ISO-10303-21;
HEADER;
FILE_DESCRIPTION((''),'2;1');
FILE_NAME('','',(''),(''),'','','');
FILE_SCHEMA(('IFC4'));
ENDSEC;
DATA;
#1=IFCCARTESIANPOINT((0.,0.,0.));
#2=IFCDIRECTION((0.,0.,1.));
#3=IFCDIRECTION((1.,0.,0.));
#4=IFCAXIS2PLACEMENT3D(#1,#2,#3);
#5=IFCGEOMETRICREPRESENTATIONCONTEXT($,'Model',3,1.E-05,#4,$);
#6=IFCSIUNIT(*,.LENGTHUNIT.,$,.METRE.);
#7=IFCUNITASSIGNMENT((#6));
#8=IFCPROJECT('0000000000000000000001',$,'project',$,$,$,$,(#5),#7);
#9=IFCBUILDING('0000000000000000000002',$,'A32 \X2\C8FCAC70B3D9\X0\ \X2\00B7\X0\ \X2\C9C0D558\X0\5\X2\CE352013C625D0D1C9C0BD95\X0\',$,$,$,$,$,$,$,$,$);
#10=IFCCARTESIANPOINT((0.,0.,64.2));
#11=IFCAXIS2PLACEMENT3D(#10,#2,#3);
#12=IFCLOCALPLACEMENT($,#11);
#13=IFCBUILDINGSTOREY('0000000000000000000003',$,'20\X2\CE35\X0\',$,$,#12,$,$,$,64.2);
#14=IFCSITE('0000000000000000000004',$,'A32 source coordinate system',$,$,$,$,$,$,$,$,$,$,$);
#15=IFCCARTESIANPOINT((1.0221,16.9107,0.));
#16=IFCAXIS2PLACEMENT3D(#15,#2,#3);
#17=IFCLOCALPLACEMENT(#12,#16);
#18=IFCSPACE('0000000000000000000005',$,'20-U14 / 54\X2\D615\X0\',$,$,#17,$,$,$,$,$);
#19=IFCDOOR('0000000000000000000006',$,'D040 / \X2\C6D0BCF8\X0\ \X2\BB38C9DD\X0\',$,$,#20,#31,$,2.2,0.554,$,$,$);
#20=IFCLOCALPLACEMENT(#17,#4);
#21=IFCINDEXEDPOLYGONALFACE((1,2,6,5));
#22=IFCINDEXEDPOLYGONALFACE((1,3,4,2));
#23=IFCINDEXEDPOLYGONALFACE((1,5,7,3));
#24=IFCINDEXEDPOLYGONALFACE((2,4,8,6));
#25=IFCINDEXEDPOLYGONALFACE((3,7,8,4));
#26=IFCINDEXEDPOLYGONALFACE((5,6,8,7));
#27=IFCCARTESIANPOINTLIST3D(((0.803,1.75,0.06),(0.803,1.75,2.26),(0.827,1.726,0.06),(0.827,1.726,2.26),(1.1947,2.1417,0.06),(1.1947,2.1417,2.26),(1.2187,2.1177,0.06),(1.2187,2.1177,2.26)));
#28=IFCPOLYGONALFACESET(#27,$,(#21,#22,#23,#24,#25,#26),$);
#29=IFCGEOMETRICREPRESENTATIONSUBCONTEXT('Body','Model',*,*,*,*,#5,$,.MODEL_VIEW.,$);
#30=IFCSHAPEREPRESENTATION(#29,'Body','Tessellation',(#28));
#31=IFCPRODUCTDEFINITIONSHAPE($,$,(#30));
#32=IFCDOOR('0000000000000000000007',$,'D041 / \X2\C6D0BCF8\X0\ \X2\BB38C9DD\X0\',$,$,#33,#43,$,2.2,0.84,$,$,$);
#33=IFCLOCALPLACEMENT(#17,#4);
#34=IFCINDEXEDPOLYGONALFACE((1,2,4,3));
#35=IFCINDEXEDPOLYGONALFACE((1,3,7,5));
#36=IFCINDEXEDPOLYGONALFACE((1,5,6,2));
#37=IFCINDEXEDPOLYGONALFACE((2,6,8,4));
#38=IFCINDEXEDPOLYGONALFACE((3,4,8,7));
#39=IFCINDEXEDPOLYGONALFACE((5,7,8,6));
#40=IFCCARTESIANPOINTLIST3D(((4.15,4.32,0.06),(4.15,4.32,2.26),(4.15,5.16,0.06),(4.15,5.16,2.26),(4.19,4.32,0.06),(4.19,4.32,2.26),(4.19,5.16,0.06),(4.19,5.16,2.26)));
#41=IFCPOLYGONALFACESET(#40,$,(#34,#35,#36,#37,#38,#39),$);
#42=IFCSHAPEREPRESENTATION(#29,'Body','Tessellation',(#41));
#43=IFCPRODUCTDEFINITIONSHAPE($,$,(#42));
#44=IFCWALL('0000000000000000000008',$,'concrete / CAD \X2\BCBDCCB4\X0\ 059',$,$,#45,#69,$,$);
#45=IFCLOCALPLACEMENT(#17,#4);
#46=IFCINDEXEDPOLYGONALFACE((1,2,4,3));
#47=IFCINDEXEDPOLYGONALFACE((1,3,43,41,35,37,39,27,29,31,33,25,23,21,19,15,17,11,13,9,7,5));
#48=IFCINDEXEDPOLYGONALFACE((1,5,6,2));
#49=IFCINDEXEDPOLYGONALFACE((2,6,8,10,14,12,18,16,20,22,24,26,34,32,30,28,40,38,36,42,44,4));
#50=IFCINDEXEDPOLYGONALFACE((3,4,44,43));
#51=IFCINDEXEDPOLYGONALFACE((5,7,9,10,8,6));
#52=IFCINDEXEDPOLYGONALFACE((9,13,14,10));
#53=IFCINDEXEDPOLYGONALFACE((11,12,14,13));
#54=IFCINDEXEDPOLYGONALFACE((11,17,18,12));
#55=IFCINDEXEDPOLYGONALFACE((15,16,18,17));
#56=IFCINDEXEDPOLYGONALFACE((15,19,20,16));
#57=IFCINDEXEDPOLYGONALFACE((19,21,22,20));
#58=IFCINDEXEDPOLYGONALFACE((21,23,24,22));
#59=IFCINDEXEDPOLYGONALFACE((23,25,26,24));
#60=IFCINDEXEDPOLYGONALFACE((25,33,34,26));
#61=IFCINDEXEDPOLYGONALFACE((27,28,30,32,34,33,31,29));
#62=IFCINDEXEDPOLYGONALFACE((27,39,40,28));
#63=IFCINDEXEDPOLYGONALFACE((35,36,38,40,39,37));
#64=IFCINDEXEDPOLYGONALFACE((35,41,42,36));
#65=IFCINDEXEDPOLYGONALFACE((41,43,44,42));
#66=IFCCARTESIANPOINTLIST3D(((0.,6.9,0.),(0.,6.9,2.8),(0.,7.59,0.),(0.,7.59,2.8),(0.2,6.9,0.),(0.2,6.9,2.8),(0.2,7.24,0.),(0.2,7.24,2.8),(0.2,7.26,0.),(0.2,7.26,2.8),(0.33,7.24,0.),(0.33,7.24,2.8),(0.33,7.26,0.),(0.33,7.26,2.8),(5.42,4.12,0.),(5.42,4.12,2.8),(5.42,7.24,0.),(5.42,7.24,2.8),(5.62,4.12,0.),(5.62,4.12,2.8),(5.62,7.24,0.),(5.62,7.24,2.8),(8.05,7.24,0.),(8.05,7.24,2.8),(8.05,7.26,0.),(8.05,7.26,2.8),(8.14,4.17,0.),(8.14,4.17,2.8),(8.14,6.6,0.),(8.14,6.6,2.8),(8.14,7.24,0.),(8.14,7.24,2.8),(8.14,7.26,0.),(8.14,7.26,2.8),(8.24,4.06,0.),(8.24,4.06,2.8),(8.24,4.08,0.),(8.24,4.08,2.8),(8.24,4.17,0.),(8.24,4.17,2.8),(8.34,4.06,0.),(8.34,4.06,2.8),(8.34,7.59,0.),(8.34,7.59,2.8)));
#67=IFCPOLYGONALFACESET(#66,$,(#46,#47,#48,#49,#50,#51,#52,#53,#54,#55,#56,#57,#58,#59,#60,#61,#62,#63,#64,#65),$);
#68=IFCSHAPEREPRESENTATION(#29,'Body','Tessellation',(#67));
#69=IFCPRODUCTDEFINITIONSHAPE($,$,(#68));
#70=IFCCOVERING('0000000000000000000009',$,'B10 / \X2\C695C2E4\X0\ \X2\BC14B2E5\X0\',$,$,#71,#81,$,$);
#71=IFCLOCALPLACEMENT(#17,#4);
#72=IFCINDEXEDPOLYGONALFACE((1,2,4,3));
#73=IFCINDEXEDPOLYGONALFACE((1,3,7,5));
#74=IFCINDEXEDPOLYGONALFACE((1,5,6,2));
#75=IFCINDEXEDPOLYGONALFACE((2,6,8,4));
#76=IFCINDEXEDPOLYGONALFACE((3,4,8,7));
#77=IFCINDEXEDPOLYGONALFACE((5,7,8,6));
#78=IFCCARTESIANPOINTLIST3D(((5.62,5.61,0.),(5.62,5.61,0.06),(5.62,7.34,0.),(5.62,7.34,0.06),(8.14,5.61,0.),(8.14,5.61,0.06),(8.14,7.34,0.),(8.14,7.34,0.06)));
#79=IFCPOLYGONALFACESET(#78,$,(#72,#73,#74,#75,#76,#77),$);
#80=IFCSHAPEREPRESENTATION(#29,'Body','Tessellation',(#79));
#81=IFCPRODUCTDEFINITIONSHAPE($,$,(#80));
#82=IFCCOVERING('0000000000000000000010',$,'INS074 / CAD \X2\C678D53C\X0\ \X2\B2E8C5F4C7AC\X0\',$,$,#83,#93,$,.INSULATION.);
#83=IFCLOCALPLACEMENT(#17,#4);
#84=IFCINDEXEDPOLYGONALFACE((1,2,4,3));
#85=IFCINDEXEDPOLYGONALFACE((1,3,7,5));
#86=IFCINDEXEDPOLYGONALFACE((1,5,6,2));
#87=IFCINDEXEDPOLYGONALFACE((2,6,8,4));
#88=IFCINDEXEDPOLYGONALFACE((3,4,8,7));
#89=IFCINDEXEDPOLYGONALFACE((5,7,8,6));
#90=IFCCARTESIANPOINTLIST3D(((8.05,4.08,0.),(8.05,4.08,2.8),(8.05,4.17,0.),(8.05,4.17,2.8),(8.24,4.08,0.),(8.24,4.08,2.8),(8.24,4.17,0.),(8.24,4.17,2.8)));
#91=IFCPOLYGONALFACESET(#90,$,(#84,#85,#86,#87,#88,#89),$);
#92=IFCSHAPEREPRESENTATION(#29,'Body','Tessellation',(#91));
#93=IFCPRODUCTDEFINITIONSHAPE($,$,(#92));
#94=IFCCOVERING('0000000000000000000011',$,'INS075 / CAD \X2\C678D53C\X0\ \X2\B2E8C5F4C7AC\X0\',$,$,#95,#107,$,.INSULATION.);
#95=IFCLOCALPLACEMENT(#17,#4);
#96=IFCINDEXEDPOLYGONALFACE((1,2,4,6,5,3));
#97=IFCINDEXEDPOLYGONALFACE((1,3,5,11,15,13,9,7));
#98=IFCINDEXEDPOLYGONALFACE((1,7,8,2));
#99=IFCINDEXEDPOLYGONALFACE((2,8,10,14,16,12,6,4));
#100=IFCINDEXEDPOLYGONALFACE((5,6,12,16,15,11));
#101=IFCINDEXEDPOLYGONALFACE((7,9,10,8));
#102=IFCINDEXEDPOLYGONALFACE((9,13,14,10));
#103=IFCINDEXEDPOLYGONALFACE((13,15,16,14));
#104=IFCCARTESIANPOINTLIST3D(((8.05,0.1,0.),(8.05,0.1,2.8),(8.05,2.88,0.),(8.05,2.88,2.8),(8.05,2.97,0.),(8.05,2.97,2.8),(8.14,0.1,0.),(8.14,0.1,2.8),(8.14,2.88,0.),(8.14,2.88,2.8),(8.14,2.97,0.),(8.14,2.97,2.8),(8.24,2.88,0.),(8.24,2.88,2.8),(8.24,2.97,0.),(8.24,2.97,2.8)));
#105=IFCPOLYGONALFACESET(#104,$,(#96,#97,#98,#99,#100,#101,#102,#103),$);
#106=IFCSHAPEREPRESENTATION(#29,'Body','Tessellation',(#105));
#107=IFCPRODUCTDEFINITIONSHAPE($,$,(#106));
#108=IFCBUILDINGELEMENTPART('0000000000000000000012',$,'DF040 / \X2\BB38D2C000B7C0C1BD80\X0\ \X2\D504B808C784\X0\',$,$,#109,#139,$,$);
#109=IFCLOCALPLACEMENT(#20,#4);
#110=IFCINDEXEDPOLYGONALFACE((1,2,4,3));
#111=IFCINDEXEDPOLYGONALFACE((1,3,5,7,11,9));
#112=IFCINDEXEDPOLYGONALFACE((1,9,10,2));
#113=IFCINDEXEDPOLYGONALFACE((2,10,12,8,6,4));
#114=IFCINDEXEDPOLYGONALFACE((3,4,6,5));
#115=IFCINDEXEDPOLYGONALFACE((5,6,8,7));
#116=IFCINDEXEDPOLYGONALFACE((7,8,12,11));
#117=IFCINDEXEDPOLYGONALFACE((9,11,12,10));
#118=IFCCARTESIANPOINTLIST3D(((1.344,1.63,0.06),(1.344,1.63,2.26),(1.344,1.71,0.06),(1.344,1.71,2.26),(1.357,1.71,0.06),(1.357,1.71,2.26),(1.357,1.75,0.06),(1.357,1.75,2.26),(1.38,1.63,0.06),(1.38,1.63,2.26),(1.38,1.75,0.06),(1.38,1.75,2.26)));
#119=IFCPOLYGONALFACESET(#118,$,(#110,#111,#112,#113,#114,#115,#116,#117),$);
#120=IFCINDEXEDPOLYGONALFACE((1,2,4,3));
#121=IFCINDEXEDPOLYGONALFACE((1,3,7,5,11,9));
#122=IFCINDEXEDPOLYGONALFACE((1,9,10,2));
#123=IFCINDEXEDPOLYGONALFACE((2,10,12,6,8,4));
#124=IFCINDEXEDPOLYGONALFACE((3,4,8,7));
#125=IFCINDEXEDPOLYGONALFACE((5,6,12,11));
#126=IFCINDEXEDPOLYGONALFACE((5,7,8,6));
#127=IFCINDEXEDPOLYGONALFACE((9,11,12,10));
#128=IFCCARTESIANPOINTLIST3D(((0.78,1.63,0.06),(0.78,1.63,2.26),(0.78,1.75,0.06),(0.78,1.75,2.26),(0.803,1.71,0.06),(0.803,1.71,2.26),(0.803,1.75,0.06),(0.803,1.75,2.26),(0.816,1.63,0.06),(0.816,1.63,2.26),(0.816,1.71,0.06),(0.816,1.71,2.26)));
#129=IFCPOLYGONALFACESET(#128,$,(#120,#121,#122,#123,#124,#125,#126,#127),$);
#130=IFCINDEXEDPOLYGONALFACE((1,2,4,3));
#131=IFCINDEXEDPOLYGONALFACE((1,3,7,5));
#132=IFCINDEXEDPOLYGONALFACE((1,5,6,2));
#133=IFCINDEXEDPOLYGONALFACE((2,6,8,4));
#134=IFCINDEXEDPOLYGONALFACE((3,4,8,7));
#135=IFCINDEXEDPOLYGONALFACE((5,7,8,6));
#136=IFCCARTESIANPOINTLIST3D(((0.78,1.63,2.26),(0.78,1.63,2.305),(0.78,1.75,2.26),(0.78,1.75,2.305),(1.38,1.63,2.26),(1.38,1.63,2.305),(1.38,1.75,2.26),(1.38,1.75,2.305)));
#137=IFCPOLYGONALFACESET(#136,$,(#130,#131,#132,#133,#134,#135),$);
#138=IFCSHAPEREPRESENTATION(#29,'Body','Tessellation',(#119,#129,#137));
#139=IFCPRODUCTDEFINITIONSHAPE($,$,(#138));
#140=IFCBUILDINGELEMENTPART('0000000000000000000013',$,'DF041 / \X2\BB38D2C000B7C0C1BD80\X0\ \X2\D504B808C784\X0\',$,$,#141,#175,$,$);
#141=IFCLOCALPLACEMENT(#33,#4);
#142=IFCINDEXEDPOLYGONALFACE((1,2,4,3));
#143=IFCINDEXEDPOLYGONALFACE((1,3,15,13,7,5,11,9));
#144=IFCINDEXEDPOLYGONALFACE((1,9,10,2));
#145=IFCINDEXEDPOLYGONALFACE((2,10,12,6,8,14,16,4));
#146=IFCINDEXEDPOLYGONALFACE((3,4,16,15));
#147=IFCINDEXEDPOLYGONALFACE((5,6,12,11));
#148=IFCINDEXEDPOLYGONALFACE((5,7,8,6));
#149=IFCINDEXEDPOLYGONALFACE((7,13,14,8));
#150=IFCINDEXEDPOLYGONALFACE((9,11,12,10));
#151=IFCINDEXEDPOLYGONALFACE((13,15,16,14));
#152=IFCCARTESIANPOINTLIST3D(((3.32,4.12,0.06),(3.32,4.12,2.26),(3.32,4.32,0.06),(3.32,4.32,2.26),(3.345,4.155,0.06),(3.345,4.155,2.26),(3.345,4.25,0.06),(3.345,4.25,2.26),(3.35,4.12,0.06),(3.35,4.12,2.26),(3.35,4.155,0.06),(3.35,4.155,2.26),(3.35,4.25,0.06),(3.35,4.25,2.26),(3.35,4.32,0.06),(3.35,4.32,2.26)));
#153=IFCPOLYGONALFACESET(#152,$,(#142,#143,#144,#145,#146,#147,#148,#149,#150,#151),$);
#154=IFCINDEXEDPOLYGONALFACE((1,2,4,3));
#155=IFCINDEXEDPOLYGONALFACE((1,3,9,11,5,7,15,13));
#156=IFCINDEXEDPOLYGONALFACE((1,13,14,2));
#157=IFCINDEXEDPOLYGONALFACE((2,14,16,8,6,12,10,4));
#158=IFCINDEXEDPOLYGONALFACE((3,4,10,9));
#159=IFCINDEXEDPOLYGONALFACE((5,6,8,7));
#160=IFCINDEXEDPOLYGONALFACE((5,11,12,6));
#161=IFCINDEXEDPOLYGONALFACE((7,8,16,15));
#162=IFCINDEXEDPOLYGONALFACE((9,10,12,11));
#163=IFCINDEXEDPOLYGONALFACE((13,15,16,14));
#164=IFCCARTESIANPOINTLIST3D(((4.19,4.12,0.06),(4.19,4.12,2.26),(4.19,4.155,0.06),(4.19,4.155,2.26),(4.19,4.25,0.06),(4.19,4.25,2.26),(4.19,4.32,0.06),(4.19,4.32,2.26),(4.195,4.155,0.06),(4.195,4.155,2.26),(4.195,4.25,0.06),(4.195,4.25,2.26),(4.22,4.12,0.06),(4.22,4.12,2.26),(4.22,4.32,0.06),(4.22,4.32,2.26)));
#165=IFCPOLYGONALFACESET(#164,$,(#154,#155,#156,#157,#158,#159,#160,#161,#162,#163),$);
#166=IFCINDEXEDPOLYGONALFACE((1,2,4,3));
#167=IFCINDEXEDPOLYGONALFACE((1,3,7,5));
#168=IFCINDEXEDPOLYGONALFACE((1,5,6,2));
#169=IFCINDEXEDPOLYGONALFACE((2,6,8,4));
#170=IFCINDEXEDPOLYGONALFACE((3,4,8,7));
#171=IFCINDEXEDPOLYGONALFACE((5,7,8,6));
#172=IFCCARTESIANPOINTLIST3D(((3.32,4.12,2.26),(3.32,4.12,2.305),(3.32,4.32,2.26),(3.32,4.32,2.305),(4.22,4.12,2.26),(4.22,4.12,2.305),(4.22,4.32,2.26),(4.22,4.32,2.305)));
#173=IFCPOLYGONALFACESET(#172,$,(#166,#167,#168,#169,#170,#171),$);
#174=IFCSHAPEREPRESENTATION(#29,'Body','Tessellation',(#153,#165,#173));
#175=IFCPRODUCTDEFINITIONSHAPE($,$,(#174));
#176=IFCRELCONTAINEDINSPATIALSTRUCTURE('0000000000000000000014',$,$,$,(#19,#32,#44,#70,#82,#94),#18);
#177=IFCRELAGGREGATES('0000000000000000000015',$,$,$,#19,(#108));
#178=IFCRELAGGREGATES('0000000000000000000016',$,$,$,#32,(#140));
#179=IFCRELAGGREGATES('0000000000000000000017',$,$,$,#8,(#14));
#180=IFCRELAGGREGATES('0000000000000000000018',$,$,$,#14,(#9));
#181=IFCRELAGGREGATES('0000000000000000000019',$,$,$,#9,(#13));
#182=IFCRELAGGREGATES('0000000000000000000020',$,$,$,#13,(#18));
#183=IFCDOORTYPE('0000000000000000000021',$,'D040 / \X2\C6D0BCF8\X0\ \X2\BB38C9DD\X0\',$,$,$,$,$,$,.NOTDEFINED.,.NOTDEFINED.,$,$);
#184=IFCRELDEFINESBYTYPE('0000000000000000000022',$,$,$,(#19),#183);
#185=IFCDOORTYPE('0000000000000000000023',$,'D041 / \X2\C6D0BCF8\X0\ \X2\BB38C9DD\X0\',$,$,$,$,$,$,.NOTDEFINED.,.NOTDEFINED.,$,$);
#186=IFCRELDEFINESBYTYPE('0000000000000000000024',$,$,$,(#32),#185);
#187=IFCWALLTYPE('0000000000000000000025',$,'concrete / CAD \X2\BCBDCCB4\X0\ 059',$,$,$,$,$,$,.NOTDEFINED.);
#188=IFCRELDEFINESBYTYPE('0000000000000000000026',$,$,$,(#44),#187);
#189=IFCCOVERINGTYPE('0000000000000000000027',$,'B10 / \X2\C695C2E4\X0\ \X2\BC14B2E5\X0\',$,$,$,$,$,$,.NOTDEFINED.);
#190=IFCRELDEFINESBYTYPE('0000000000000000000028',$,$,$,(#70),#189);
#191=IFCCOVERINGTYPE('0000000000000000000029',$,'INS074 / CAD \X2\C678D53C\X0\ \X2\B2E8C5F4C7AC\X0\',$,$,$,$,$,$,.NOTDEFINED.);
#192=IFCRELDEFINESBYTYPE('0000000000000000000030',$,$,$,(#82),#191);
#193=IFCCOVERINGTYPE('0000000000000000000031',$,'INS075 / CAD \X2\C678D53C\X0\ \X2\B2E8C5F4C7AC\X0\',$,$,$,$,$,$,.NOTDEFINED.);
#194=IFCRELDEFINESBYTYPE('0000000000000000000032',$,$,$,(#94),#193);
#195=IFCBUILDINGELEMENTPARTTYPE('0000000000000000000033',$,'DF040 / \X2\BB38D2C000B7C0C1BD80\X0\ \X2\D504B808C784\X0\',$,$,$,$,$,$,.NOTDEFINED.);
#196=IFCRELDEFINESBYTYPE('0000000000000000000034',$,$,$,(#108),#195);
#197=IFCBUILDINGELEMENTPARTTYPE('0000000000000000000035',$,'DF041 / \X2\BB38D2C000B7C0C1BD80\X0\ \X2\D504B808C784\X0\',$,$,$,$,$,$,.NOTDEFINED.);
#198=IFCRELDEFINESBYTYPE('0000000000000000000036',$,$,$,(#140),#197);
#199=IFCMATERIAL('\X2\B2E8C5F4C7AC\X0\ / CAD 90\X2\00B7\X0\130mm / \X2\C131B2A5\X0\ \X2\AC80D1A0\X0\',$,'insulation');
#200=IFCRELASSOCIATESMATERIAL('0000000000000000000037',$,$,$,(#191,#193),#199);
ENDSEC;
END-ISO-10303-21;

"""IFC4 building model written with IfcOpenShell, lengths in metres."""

from ifc_helpers import new_model, si_unit, frame, origin, origin_with_axes, place, context, subcontext, project, spatial, polyline, outline, extrude, source, transform, mapped, material, type_object, type_shapes, element, aggregate, save


model = new_model("IFC4")

# Units and contexts
model_context = context("Model", 3, precision=1e-05, world=origin_with_axes())
body_context = subcontext(model_context, "Body", "Model", "MODEL_VIEW")
ifc_project = project(units=[si_unit("LENGTHUNIT", "METRE")], contexts=[model_context])

# Site, building, storey, space
storey_placement = place(None, frame((0.0, 0.0, 64.2), z_axis=(0.0, 0.0, 1.0), x_axis=(1.0, 0.0, 0.0)))
space_1_placement = place(storey_placement, frame((1.0221, 16.9107, 0.0), z_axis=(0.0, 0.0, 1.0), x_axis=(1.0, 0.0, 0.0)))
site = spatial("IfcSite", under=ifc_project, Name="A32 source coordinate system")
building = spatial("IfcBuilding", under=site, Name="A32 주거동 · 지하5층–옥탑지붕")
storey = spatial("IfcBuildingStorey", under=building, at=storey_placement, Name="20층", Elevation=64.2)
space_1 = spatial("IfcSpace", under=storey, at=space_1_placement, Name="20-U14 / 54형")

# Doors
door_type_1 = type_object("IfcDoorType", Name="D040 / 원본 문짝", OperationType="NOTDEFINED", PredefinedType="NOTDEFINED")
shared_shape_1 = source(origin(), body_context, "Body", "SweptSolid", [
    extrude(outline(polyline([(0.803, 1.75), (1.1947, 2.1417), (1.2187, 2.1177), (0.827, 1.726), (0.803, 1.75)])), frame((0.0, 0.0, 0.06)), (0.0, 0.0, 1.0), 2.2),
])
type_shapes(door_type_1, [shared_shape_1])
door_1_placement = place(space_1_placement, origin_with_axes())
door_1 = element("IfcDoor", 1, at=door_1_placement, inside=space_1, type_object=door_type_1, Name="D040 / 원본 문짝", OverallHeight=2.2, OverallWidth=0.554, context=body_context, shape_type="MappedRepresentation", body=[
    mapped(shared_shape_1, transform((0.0, 0.0, 0.0), scale=1.0)),
])
door_type_2 = type_object("IfcDoorType", Name="D041 / 원본 문짝", OperationType="NOTDEFINED", PredefinedType="NOTDEFINED")
shared_shape_2 = source(origin(), body_context, "Body", "SweptSolid", [
    extrude(outline(polyline([(4.15, 5.16), (4.19, 5.16), (4.19, 4.32), (4.15, 4.32), (4.15, 5.16)])), frame((0.0, 0.0, 0.06)), (0.0, 0.0, 1.0), 2.2),
])
type_shapes(door_type_2, [shared_shape_2])
door_2_placement = place(space_1_placement, origin_with_axes())
door_2 = element("IfcDoor", 2, at=door_2_placement, inside=space_1, type_object=door_type_2, Name="D041 / 원본 문짝", OverallHeight=2.2, OverallWidth=0.84, context=body_context, shape_type="MappedRepresentation", body=[
    mapped(shared_shape_2, transform((0.0, 0.0, 0.0), scale=1.0)),
])

# Wall
wall_type_1 = type_object("IfcWallType", Name="concrete / CAD 벽체 059", PredefinedType="NOTDEFINED")
shared_shape_3 = source(origin(), body_context, "Body", "SweptSolid", [
    extrude(outline(polyline([(8.05, 7.26), (8.05, 7.24), (5.62, 7.24), (5.62, 4.12), (5.42, 4.12), (5.42, 7.24), (0.33, 7.24), (0.33, 7.26), (0.2, 7.26), (0.2, 7.24), (0.2, 6.9), (0.0, 6.9), (0.0, 7.59), (8.34, 7.59), (8.34, 4.06), (8.24, 4.06), (8.24, 4.08), (8.24, 4.17), (8.14, 4.17), (8.14, 6.6), (8.14, 7.24), (8.14, 7.26), (8.05, 7.26)])), origin(), (0.0, 0.0, 1.0), 2.8),
])
type_shapes(wall_type_1, [shared_shape_3])
wall_1_placement = place(space_1_placement, origin_with_axes())
element("IfcWall", 3, at=wall_1_placement, inside=space_1, type_object=wall_type_1, Name="concrete / CAD 벽체 059", context=body_context, shape_type="MappedRepresentation", body=[
    mapped(shared_shape_3, transform((0.0, 0.0, 0.0), scale=1.0)),
])

# Coverings
covering_type_1 = type_object("IfcCoveringType", Name="B10 / 욕실 바닥", PredefinedType="NOTDEFINED")
shared_shape_4 = source(origin(), body_context, "Body", "SweptSolid", [
    extrude(outline(polyline([(8.14, 5.61), (5.62, 5.61), (5.62, 7.34), (8.14, 7.34), (8.14, 5.61)])), origin(), (0.0, 0.0, 1.0), 0.06),
])
type_shapes(covering_type_1, [shared_shape_4])
covering_1_placement = place(space_1_placement, origin_with_axes())
element("IfcCovering", 4, at=covering_1_placement, inside=space_1, type_object=covering_type_1, Name="B10 / 욕실 바닥", context=body_context, shape_type="MappedRepresentation", body=[
    mapped(shared_shape_4, transform((0.0, 0.0, 0.0), scale=1.0)),
])
ifc_material = material(Name="단열재 / CAD 90·130mm / 성능 검토", Category="insulation")
covering_type_2 = type_object("IfcCoveringType", Name="INS074 / CAD 외피 단열재", PredefinedType="NOTDEFINED", material=ifc_material)
shared_shape_5 = source(origin(), body_context, "Body", "SweptSolid", [
    extrude(outline(polyline([(8.05, 4.08), (8.05, 4.17), (8.24, 4.17), (8.24, 4.08), (8.05, 4.08)])), origin(), (0.0, 0.0, 1.0), 2.8),
])
type_shapes(covering_type_2, [shared_shape_5])
covering_2_placement = place(space_1_placement, origin_with_axes())
element("IfcCovering", 5, at=covering_2_placement, inside=space_1, type_object=covering_type_2, Name="INS074 / CAD 외피 단열재", PredefinedType="INSULATION", context=body_context, shape_type="MappedRepresentation", body=[
    mapped(shared_shape_5, transform((0.0, 0.0, 0.0), scale=1.0)),
])
covering_type_3 = type_object("IfcCoveringType", Name="INS075 / CAD 외피 단열재", PredefinedType="NOTDEFINED", material=ifc_material)
shared_shape_6 = source(origin(), body_context, "Body", "SweptSolid", [
    extrude(outline(polyline([(8.24, 2.88), (8.14, 2.88), (8.14, 0.1), (8.05, 0.1), (8.05, 2.88), (8.05, 2.97), (8.14, 2.97), (8.24, 2.97), (8.24, 2.88)])), origin(), (0.0, 0.0, 1.0), 2.8),
])
type_shapes(covering_type_3, [shared_shape_6])
covering_3_placement = place(space_1_placement, origin_with_axes())
element("IfcCovering", 6, at=covering_3_placement, inside=space_1, type_object=covering_type_3, Name="INS075 / CAD 외피 단열재", PredefinedType="INSULATION", context=body_context, shape_type="MappedRepresentation", body=[
    mapped(shared_shape_6, transform((0.0, 0.0, 0.0), scale=1.0)),
])

# Building element parts
building_element_part_type_1 = type_object("IfcBuildingElementPartType", Name="DF040 / 문틀·상부 프레임", PredefinedType="NOTDEFINED")
shared_shape_7 = source(origin(), body_context, "Body", "SweptSolid", [
    extrude(outline(polyline([(1.344, 1.63), (1.344, 1.71), (1.357, 1.71), (1.357, 1.75), (1.38, 1.75), (1.38, 1.63), (1.344, 1.63)])), frame((0.0, 0.0, 0.06)), (0.0, 0.0, 1.0), 2.2),
    extrude(outline(polyline([(0.78, 1.75), (0.803, 1.75), (0.803, 1.71), (0.816, 1.71), (0.816, 1.63), (0.78, 1.63), (0.78, 1.75)])), frame((0.0, 0.0, 0.06)), (0.0, 0.0, 1.0), 2.2),
    extrude(outline(polyline([(0.78, 1.63), (0.78, 1.75), (1.38, 1.75), (1.38, 1.63), (0.78, 1.63)])), frame((0.0, 0.0, 2.26)), (0.0, 0.0, 1.0), 0.045),
])
type_shapes(building_element_part_type_1, [shared_shape_7])
building_element_part_1_placement = place(door_1_placement, origin_with_axes())
building_element_part_1 = element("IfcBuildingElementPart", 7, at=building_element_part_1_placement, type_object=building_element_part_type_1, Name="DF040 / 문틀·상부 프레임", context=body_context, shape_type="MappedRepresentation", body=[
    mapped(shared_shape_7, transform((0.0, 0.0, 0.0), scale=1.0)),
])
aggregate(door_1, [building_element_part_1])
building_element_part_type_2 = type_object("IfcBuildingElementPartType", Name="DF041 / 문틀·상부 프레임", PredefinedType="NOTDEFINED")
shared_shape_8 = source(origin(), body_context, "Body", "SweptSolid", [
    extrude(outline(polyline([(3.35, 4.32), (3.35, 4.25), (3.345, 4.25), (3.345, 4.155), (3.35, 4.155), (3.35, 4.12), (3.32, 4.12), (3.32, 4.32), (3.35, 4.32)])), frame((0.0, 0.0, 0.06)), (0.0, 0.0, 1.0), 2.2),
    extrude(outline(polyline([(4.22, 4.12), (4.19, 4.12), (4.19, 4.155), (4.195, 4.155), (4.195, 4.25), (4.19, 4.25), (4.19, 4.32), (4.22, 4.32), (4.22, 4.12)])), frame((0.0, 0.0, 0.06)), (0.0, 0.0, 1.0), 2.2),
    extrude(outline(polyline([(3.32, 4.12), (3.32, 4.32), (4.22, 4.32), (4.22, 4.12), (3.32, 4.12)])), frame((0.0, 0.0, 2.26)), (0.0, 0.0, 1.0), 0.045),
])
type_shapes(building_element_part_type_2, [shared_shape_8])
building_element_part_2_placement = place(door_2_placement, origin_with_axes())
building_element_part_2 = element("IfcBuildingElementPart", 8, at=building_element_part_2_placement, type_object=building_element_part_type_2, Name="DF041 / 문틀·상부 프레임", context=body_context, shape_type="MappedRepresentation", body=[
    mapped(shared_shape_8, transform((0.0, 0.0, 0.0), scale=1.0)),
])
aggregate(door_2, [building_element_part_2])

save(model, "model.ifc")
